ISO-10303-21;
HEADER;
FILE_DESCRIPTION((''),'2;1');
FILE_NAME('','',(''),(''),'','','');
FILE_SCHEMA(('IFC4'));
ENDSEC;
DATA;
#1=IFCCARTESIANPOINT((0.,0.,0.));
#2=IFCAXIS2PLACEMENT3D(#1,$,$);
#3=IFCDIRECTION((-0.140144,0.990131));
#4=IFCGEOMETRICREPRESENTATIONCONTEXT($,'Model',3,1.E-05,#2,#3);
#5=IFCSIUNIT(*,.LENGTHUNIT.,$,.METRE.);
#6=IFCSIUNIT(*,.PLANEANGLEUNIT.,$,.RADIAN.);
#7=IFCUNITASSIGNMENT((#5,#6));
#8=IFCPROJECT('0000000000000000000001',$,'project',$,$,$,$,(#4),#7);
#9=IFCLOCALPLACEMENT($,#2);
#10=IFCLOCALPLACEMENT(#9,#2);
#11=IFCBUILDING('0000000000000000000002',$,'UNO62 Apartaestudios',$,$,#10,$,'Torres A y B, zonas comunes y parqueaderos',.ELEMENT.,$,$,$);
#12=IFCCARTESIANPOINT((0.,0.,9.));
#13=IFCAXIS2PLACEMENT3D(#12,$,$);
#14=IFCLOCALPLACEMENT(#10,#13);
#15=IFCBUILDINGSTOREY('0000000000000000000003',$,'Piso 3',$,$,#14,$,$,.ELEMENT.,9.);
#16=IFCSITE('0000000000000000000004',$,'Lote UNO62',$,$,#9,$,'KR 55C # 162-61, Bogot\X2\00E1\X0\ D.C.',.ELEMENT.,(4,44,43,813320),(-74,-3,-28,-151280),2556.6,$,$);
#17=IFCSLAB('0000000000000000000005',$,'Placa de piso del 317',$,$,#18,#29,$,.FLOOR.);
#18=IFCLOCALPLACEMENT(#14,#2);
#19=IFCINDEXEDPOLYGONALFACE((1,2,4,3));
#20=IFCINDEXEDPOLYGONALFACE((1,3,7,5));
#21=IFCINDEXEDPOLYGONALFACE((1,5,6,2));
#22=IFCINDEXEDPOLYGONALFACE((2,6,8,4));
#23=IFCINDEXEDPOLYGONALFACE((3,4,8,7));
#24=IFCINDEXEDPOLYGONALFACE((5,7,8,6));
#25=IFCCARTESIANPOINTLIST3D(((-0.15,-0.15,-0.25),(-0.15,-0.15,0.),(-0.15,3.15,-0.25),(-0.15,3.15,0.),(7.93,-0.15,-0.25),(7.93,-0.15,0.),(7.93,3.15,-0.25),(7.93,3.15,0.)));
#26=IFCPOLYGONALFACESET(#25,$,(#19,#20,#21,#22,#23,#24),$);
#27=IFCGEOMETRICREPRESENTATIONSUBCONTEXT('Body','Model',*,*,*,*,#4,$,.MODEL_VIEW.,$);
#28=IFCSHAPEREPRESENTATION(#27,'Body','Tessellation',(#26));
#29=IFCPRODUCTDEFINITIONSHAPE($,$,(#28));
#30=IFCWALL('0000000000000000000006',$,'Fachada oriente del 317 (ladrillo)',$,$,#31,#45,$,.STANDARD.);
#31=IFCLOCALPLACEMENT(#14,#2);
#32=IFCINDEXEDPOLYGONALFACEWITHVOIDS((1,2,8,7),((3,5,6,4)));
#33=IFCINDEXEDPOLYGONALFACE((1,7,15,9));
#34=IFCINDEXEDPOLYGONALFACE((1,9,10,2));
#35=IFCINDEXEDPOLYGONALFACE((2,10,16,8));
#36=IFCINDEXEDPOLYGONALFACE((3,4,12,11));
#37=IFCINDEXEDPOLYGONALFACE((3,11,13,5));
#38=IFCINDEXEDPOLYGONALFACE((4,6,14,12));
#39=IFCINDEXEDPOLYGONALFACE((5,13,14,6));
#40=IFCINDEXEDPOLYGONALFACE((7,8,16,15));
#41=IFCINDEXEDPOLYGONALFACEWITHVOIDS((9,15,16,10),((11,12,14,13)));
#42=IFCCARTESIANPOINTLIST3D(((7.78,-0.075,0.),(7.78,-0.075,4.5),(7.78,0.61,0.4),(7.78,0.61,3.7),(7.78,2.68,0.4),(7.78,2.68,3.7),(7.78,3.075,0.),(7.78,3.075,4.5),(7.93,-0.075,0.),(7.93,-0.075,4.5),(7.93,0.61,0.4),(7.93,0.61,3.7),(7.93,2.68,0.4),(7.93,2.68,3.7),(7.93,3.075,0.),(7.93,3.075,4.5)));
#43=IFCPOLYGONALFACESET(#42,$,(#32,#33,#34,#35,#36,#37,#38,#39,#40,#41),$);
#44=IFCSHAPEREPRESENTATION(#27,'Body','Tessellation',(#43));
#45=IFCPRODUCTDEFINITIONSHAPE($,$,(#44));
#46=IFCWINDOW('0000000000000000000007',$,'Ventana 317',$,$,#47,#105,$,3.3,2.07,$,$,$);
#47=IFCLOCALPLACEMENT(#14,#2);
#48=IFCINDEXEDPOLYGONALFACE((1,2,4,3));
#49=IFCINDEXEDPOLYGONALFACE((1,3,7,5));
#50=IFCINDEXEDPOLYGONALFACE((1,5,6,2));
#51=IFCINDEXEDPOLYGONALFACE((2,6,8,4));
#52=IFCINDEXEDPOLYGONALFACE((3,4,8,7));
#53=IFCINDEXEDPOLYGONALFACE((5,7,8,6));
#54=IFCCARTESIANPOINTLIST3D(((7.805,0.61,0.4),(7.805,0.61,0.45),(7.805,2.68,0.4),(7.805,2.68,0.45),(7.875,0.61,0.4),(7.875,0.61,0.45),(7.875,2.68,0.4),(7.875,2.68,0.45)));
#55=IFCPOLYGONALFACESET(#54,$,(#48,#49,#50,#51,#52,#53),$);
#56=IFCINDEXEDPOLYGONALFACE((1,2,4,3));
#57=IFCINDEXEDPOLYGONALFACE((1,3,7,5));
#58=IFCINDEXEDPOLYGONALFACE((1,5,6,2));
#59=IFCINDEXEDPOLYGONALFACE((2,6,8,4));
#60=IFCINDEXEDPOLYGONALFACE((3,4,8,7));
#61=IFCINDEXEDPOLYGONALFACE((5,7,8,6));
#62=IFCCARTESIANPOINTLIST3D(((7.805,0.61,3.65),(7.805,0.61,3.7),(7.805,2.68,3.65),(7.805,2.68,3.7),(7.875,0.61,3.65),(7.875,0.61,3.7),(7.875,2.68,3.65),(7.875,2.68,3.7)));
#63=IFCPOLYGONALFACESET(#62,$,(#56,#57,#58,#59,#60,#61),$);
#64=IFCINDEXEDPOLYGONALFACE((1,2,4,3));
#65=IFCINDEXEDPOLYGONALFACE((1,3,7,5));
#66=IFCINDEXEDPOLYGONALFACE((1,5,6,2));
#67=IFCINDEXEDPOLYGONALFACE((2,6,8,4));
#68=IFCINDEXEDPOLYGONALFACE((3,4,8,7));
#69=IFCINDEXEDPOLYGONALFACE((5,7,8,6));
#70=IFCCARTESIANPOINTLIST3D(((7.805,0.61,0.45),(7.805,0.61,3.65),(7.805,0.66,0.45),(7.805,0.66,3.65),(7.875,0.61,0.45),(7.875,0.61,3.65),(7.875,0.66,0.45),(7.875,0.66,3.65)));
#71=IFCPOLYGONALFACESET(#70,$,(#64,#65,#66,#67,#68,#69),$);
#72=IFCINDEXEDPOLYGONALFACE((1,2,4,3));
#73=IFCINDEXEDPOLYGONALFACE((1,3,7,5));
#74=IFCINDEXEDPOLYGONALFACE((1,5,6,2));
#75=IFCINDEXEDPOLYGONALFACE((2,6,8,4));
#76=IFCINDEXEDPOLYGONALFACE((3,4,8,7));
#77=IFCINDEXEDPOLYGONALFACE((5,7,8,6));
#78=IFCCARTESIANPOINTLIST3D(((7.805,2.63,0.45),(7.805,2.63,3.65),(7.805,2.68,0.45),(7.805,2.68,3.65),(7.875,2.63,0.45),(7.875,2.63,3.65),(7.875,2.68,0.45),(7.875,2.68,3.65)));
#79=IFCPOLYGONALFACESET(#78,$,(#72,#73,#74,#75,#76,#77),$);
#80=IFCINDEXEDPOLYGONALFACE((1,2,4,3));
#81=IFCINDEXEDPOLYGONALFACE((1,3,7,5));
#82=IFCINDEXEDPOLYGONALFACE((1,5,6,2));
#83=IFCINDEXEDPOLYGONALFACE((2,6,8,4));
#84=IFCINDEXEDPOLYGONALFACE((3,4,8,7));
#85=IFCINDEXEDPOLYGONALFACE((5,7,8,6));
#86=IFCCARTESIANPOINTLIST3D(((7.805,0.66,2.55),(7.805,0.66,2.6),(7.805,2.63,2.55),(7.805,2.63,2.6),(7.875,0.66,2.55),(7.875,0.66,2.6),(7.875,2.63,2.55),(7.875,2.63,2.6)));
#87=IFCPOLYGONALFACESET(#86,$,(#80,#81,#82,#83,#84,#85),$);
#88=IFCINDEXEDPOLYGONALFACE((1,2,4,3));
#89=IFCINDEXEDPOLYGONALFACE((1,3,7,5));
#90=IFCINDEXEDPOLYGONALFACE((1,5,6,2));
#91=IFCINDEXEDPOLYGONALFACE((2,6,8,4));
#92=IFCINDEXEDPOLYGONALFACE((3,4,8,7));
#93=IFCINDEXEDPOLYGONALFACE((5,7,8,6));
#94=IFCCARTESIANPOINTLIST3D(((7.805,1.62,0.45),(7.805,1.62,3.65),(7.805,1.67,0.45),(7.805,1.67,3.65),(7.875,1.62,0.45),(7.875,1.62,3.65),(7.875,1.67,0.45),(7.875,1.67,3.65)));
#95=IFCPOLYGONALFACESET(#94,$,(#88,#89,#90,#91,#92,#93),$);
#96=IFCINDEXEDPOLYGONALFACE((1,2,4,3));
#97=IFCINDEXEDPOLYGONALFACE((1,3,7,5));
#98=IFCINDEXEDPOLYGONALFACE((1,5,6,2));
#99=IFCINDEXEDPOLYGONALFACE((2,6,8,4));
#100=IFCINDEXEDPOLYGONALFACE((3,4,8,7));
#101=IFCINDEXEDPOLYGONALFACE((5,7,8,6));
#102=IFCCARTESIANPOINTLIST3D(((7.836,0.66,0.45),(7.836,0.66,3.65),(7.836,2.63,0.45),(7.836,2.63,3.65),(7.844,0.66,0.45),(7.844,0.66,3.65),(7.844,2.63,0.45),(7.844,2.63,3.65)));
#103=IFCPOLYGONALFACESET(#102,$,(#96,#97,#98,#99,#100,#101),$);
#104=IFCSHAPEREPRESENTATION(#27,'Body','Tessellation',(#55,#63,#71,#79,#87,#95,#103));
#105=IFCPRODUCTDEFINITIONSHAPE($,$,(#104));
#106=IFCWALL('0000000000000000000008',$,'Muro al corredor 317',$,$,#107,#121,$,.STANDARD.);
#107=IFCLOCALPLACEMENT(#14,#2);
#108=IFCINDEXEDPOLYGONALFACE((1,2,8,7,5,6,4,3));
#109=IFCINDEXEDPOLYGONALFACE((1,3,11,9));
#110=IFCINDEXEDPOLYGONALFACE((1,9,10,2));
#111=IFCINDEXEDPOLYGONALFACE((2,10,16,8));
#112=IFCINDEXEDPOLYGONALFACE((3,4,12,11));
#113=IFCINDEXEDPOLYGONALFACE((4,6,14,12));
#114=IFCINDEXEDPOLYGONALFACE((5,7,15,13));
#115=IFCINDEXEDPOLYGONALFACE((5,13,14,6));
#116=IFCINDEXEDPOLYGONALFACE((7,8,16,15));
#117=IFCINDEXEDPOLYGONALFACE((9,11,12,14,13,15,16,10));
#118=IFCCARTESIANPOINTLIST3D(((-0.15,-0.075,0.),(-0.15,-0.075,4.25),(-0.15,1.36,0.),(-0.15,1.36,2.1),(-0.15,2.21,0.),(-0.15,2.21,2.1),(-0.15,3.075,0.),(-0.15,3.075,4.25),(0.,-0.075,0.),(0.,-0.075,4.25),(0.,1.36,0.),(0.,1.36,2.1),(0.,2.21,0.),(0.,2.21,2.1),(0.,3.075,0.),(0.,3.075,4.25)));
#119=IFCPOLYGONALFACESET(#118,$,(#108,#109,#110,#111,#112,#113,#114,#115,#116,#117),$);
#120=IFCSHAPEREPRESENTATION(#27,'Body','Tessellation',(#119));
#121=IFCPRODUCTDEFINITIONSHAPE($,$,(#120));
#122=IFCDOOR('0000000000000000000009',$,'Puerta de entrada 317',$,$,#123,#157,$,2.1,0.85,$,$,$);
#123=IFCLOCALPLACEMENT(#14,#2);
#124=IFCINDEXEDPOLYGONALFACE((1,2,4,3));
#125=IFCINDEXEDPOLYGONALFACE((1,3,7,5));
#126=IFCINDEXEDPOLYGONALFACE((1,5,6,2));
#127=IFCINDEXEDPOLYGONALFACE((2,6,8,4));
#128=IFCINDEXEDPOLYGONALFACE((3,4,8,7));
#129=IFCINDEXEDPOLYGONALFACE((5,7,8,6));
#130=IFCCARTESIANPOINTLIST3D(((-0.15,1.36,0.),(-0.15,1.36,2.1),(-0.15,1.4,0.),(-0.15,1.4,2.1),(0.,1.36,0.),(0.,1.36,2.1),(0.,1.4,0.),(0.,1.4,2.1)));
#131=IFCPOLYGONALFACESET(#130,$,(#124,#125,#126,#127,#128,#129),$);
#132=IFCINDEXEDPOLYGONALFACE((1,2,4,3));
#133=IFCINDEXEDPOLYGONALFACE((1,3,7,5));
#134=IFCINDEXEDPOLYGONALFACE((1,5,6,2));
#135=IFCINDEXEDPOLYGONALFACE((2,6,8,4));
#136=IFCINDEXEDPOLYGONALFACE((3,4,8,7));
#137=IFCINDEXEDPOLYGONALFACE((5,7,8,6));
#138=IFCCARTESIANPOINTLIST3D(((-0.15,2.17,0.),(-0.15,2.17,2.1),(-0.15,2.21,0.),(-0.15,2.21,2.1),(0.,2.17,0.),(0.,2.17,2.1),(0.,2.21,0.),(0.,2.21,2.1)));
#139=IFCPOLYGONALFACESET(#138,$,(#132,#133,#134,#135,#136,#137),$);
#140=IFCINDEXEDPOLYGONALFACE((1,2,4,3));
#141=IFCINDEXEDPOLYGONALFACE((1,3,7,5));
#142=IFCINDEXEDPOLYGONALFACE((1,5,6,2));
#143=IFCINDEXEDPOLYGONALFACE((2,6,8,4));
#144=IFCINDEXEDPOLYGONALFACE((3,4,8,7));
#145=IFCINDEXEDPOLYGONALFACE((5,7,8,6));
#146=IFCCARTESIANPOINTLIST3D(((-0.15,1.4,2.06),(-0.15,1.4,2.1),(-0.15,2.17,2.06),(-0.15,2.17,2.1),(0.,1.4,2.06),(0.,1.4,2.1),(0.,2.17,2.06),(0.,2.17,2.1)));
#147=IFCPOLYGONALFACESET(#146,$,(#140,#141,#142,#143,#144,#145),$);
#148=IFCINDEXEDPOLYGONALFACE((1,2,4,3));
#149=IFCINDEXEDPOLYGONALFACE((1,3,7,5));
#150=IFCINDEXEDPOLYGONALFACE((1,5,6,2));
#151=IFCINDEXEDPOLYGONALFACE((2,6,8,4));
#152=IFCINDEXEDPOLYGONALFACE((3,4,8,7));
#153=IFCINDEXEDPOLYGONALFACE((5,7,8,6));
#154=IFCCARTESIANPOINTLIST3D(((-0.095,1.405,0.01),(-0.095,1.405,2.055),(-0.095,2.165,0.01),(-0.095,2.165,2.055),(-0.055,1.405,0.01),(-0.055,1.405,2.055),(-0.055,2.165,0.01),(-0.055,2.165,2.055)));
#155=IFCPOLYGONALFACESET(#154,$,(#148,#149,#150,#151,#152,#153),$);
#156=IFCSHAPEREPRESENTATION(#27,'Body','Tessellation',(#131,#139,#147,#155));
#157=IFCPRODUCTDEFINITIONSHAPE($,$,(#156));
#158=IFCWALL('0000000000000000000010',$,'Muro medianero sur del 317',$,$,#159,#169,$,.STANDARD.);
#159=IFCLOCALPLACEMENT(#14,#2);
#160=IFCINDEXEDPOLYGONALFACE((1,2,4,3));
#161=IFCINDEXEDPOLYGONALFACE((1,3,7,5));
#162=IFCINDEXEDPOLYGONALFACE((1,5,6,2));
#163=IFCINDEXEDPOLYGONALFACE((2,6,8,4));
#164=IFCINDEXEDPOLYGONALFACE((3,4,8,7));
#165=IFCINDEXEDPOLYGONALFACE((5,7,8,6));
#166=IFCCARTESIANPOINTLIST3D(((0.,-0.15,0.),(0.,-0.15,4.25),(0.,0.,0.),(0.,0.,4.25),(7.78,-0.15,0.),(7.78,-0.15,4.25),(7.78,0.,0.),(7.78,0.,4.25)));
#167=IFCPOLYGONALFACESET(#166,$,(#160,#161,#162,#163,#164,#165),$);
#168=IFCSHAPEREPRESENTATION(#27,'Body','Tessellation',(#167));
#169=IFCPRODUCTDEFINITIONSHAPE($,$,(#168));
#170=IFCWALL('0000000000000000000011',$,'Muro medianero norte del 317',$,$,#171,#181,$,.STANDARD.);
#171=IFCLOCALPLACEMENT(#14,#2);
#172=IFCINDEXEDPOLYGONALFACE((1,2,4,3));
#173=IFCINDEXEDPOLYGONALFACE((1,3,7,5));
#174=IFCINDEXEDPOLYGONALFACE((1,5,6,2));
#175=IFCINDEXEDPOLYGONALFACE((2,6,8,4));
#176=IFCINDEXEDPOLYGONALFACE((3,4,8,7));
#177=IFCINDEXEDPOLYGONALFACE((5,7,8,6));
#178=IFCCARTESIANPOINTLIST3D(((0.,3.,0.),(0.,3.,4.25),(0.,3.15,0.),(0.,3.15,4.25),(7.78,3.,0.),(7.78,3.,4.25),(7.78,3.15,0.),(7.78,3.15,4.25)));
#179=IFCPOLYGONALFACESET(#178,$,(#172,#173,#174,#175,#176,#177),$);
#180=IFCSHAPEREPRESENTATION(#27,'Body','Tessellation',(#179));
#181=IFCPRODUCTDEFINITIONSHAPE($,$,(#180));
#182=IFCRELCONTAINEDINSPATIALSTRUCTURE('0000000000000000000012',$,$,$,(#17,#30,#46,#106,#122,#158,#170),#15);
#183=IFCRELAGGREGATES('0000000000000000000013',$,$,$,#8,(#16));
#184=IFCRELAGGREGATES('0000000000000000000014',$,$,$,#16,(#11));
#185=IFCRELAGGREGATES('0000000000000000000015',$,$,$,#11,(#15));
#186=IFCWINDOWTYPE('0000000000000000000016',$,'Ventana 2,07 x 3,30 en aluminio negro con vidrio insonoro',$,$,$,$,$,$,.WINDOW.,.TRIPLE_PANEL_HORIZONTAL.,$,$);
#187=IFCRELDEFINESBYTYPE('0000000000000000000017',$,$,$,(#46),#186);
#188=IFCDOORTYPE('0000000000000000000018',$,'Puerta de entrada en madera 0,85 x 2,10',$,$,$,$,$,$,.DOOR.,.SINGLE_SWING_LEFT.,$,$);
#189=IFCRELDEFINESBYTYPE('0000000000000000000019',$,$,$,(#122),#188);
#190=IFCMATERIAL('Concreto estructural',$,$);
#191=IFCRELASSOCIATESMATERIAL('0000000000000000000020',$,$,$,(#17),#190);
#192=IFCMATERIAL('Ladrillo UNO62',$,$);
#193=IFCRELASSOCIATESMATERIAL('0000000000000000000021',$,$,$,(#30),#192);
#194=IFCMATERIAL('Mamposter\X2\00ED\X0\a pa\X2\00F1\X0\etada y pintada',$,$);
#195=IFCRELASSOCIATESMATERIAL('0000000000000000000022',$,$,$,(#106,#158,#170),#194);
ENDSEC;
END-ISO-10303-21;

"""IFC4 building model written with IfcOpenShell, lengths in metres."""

from ifc_helpers import new_model, si_unit, direction, frame, frame_2d, origin, place, context, subcontext, project, spatial, rectangle, extrude, source, transform, mapped, material, type_object, type_shapes, element, fill, save


model = new_model("IFC4")

# Units and contexts
model_context = context("Model", 3, precision=1e-05, world=origin(), true_north=direction((-0.140144, 0.990131)))
body_context = subcontext(model_context, "Body", "Model", "MODEL_VIEW")
ifc_project = project(units=[si_unit("LENGTHUNIT", "METRE"), si_unit("PLANEANGLEUNIT", "RADIAN")], contexts=[model_context])

# Site, building, storey
site_placement = place(None, origin())
site = spatial("IfcSite", under=ifc_project, at=site_placement, Name="Lote UNO62", LongName="KR 55C # 162-61, Bogotá D.C.", CompositionType="ELEMENT", RefLatitude=(4, 44, 43, 813320), RefLongitude=(-74, -3, -28, -151280), RefElevation=2556.6)
building_placement = place(site_placement, origin())
building = spatial("IfcBuilding", under=site, at=building_placement, Name="UNO62 Apartaestudios", LongName="Torres A y B, zonas comunes y parqueaderos", CompositionType="ELEMENT")
storey_placement = place(building_placement, frame((0.0, 0.0, 9.0)))
storey = spatial("IfcBuildingStorey", under=building, at=storey_placement, Name="Piso 3", CompositionType="ELEMENT", Elevation=9.0)

# Slab
ifc_material_1 = material(Name="Concreto estructural")
slab_placement = place(storey_placement, origin())
element("IfcSlab", 1, at=slab_placement, inside=storey, material=ifc_material_1, Name="Placa de piso del 317", PredefinedType="FLOOR", context=body_context, shape_type="SweptSolid", body=[
    extrude(rectangle(XDim=8.08, YDim=3.3, at=frame_2d((3.89, 1.5))), frame((0.0, 0.0, -0.25)), (0.0, 0.0, 1.0), 0.25),
])

# Wall, opening, window
ifc_material_2 = material(Name="Ladrillo UNO62")
wall_1_placement = place(storey_placement, origin())
wall_1 = element("IfcWall", 2, at=wall_1_placement, inside=storey, material=ifc_material_2, Name="Fachada oriente del 317 (ladrillo)", PredefinedType="STANDARD", context=body_context, shape_type="SweptSolid", body=[
    extrude(rectangle(XDim=0.15, YDim=3.15, at=frame_2d((7.855, 1.5))), origin(), (0.0, 0.0, 1.0), 4.5),
])
opening_1_placement = place(wall_1_placement, origin())
opening_1 = element("IfcOpeningElement", 3, at=opening_1_placement, cuts=wall_1, PredefinedType="OPENING", context=body_context, shape_type="SweptSolid", body=[
    extrude(rectangle(XDim=0.25, YDim=2.07, at=frame_2d((7.855, 1.645))), frame((0.0, 0.0, 0.4)), (0.0, 0.0, 1.0), 3.3),
])
window_type = type_object("IfcWindowType", Name="Ventana 2,07 x 3,30 en aluminio negro con vidrio insonoro", PartitioningType="TRIPLE_PANEL_HORIZONTAL", PredefinedType="WINDOW")
shared_shape_1 = source(origin(), body_context, "Body", "SweptSolid", [
    extrude(rectangle(XDim=0.07, YDim=2.07, at=frame_2d((7.84, 1.645))), frame((0.0, 0.0, 0.4)), (0.0, 0.0, 1.0), 0.05),
    extrude(rectangle(XDim=0.07, YDim=2.07, at=frame_2d((7.84, 1.645))), frame((0.0, 0.0, 3.65)), (0.0, 0.0, 1.0), 0.05),
    extrude(rectangle(XDim=0.07, YDim=0.05, at=frame_2d((7.84, 0.635))), frame((0.0, 0.0, 0.45)), (0.0, 0.0, 1.0), 3.2),
    extrude(rectangle(XDim=0.07, YDim=0.05, at=frame_2d((7.84, 2.655))), frame((0.0, 0.0, 0.45)), (0.0, 0.0, 1.0), 3.2),
    extrude(rectangle(XDim=0.07, YDim=1.97, at=frame_2d((7.84, 1.645))), frame((0.0, 0.0, 2.55)), (0.0, 0.0, 1.0), 0.05),
    extrude(rectangle(XDim=0.07, YDim=0.05, at=frame_2d((7.84, 1.645))), frame((0.0, 0.0, 0.45)), (0.0, 0.0, 1.0), 3.2),
    extrude(rectangle(XDim=0.008, YDim=1.97, at=frame_2d((7.84, 1.645))), frame((0.0, 0.0, 0.45)), (0.0, 0.0, 1.0), 3.2),
])
type_shapes(window_type, [shared_shape_1])
placement = place(storey_placement, origin())
window_placement = place(placement, origin())
window = element("IfcWindow", 4, at=window_placement, inside=storey, type_object=window_type, Name="Ventana 317", OverallHeight=3.3, OverallWidth=2.07, context=body_context, shape_type="MappedRepresentation", body=[
    mapped(shared_shape_1, transform((0.0, 0.0, 0.0))),
])
fill(opening_1, window)

# Wall, opening, door
ifc_material_3 = material(Name="Mampostería pañetada y pintada")
wall_2_placement = place(storey_placement, origin())
wall_2 = element("IfcWall", 5, at=wall_2_placement, inside=storey, material=ifc_material_3, Name="Muro al corredor 317", PredefinedType="STANDARD", context=body_context, shape_type="SweptSolid", body=[
    extrude(rectangle(XDim=0.15, YDim=3.15, at=frame_2d((-0.075, 1.5))), origin(), (0.0, 0.0, 1.0), 4.25),
])
opening_2_placement = place(wall_2_placement, origin())
opening_2 = element("IfcOpeningElement", 6, at=opening_2_placement, cuts=wall_2, PredefinedType="OPENING", context=body_context, shape_type="SweptSolid", body=[
    extrude(rectangle(XDim=0.25, YDim=0.85, at=frame_2d((-0.075, 1.785))), origin(), (0.0, 0.0, 1.0), 2.1),
])
door_type = type_object("IfcDoorType", Name="Puerta de entrada en madera 0,85 x 2,10", OperationType="SINGLE_SWING_LEFT", PredefinedType="DOOR")
shared_shape_2 = source(origin(), body_context, "Body", "SweptSolid", [
    extrude(rectangle(XDim=0.15, YDim=0.04, at=frame_2d((-0.075, 1.38))), origin(), (0.0, 0.0, 1.0), 2.1),
    extrude(rectangle(XDim=0.15, YDim=0.04, at=frame_2d((-0.075, 2.19))), origin(), (0.0, 0.0, 1.0), 2.1),
    extrude(rectangle(XDim=0.15, YDim=0.77, at=frame_2d((-0.075, 1.785))), frame((0.0, 0.0, 2.06)), (0.0, 0.0, 1.0), 0.04),
    extrude(rectangle(XDim=0.04, YDim=0.76, at=frame_2d((-0.075, 1.785))), frame((0.0, 0.0, 0.01)), (0.0, 0.0, 1.0), 2.045),
])
type_shapes(door_type, [shared_shape_2])
door_placement = place(placement, origin())
door = element("IfcDoor", 7, at=door_placement, inside=storey, type_object=door_type, Name="Puerta de entrada 317", OverallHeight=2.1, OverallWidth=0.85, context=body_context, shape_type="MappedRepresentation", body=[
    mapped(shared_shape_2, transform((0.0, 0.0, 0.0))),
])
fill(opening_2, door)

# Walls
wall_3_placement = place(storey_placement, origin())
element("IfcWall", 8, at=wall_3_placement, inside=storey, material=ifc_material_3, Name="Muro medianero sur del 317", PredefinedType="STANDARD", context=body_context, shape_type="SweptSolid", body=[
    extrude(rectangle(XDim=7.78, YDim=0.15, at=frame_2d((3.89, -0.075))), origin(), (0.0, 0.0, 1.0), 4.25),
])
wall_4_placement = place(storey_placement, origin())
element("IfcWall", 9, at=wall_4_placement, inside=storey, material=ifc_material_3, Name="Muro medianero norte del 317", PredefinedType="STANDARD", context=body_context, shape_type="SweptSolid", body=[
    extrude(rectangle(XDim=7.78, YDim=0.15, at=frame_2d((3.89, 3.075))), origin(), (0.0, 0.0, 1.0), 4.25),
])

save(model, "model.ifc")
